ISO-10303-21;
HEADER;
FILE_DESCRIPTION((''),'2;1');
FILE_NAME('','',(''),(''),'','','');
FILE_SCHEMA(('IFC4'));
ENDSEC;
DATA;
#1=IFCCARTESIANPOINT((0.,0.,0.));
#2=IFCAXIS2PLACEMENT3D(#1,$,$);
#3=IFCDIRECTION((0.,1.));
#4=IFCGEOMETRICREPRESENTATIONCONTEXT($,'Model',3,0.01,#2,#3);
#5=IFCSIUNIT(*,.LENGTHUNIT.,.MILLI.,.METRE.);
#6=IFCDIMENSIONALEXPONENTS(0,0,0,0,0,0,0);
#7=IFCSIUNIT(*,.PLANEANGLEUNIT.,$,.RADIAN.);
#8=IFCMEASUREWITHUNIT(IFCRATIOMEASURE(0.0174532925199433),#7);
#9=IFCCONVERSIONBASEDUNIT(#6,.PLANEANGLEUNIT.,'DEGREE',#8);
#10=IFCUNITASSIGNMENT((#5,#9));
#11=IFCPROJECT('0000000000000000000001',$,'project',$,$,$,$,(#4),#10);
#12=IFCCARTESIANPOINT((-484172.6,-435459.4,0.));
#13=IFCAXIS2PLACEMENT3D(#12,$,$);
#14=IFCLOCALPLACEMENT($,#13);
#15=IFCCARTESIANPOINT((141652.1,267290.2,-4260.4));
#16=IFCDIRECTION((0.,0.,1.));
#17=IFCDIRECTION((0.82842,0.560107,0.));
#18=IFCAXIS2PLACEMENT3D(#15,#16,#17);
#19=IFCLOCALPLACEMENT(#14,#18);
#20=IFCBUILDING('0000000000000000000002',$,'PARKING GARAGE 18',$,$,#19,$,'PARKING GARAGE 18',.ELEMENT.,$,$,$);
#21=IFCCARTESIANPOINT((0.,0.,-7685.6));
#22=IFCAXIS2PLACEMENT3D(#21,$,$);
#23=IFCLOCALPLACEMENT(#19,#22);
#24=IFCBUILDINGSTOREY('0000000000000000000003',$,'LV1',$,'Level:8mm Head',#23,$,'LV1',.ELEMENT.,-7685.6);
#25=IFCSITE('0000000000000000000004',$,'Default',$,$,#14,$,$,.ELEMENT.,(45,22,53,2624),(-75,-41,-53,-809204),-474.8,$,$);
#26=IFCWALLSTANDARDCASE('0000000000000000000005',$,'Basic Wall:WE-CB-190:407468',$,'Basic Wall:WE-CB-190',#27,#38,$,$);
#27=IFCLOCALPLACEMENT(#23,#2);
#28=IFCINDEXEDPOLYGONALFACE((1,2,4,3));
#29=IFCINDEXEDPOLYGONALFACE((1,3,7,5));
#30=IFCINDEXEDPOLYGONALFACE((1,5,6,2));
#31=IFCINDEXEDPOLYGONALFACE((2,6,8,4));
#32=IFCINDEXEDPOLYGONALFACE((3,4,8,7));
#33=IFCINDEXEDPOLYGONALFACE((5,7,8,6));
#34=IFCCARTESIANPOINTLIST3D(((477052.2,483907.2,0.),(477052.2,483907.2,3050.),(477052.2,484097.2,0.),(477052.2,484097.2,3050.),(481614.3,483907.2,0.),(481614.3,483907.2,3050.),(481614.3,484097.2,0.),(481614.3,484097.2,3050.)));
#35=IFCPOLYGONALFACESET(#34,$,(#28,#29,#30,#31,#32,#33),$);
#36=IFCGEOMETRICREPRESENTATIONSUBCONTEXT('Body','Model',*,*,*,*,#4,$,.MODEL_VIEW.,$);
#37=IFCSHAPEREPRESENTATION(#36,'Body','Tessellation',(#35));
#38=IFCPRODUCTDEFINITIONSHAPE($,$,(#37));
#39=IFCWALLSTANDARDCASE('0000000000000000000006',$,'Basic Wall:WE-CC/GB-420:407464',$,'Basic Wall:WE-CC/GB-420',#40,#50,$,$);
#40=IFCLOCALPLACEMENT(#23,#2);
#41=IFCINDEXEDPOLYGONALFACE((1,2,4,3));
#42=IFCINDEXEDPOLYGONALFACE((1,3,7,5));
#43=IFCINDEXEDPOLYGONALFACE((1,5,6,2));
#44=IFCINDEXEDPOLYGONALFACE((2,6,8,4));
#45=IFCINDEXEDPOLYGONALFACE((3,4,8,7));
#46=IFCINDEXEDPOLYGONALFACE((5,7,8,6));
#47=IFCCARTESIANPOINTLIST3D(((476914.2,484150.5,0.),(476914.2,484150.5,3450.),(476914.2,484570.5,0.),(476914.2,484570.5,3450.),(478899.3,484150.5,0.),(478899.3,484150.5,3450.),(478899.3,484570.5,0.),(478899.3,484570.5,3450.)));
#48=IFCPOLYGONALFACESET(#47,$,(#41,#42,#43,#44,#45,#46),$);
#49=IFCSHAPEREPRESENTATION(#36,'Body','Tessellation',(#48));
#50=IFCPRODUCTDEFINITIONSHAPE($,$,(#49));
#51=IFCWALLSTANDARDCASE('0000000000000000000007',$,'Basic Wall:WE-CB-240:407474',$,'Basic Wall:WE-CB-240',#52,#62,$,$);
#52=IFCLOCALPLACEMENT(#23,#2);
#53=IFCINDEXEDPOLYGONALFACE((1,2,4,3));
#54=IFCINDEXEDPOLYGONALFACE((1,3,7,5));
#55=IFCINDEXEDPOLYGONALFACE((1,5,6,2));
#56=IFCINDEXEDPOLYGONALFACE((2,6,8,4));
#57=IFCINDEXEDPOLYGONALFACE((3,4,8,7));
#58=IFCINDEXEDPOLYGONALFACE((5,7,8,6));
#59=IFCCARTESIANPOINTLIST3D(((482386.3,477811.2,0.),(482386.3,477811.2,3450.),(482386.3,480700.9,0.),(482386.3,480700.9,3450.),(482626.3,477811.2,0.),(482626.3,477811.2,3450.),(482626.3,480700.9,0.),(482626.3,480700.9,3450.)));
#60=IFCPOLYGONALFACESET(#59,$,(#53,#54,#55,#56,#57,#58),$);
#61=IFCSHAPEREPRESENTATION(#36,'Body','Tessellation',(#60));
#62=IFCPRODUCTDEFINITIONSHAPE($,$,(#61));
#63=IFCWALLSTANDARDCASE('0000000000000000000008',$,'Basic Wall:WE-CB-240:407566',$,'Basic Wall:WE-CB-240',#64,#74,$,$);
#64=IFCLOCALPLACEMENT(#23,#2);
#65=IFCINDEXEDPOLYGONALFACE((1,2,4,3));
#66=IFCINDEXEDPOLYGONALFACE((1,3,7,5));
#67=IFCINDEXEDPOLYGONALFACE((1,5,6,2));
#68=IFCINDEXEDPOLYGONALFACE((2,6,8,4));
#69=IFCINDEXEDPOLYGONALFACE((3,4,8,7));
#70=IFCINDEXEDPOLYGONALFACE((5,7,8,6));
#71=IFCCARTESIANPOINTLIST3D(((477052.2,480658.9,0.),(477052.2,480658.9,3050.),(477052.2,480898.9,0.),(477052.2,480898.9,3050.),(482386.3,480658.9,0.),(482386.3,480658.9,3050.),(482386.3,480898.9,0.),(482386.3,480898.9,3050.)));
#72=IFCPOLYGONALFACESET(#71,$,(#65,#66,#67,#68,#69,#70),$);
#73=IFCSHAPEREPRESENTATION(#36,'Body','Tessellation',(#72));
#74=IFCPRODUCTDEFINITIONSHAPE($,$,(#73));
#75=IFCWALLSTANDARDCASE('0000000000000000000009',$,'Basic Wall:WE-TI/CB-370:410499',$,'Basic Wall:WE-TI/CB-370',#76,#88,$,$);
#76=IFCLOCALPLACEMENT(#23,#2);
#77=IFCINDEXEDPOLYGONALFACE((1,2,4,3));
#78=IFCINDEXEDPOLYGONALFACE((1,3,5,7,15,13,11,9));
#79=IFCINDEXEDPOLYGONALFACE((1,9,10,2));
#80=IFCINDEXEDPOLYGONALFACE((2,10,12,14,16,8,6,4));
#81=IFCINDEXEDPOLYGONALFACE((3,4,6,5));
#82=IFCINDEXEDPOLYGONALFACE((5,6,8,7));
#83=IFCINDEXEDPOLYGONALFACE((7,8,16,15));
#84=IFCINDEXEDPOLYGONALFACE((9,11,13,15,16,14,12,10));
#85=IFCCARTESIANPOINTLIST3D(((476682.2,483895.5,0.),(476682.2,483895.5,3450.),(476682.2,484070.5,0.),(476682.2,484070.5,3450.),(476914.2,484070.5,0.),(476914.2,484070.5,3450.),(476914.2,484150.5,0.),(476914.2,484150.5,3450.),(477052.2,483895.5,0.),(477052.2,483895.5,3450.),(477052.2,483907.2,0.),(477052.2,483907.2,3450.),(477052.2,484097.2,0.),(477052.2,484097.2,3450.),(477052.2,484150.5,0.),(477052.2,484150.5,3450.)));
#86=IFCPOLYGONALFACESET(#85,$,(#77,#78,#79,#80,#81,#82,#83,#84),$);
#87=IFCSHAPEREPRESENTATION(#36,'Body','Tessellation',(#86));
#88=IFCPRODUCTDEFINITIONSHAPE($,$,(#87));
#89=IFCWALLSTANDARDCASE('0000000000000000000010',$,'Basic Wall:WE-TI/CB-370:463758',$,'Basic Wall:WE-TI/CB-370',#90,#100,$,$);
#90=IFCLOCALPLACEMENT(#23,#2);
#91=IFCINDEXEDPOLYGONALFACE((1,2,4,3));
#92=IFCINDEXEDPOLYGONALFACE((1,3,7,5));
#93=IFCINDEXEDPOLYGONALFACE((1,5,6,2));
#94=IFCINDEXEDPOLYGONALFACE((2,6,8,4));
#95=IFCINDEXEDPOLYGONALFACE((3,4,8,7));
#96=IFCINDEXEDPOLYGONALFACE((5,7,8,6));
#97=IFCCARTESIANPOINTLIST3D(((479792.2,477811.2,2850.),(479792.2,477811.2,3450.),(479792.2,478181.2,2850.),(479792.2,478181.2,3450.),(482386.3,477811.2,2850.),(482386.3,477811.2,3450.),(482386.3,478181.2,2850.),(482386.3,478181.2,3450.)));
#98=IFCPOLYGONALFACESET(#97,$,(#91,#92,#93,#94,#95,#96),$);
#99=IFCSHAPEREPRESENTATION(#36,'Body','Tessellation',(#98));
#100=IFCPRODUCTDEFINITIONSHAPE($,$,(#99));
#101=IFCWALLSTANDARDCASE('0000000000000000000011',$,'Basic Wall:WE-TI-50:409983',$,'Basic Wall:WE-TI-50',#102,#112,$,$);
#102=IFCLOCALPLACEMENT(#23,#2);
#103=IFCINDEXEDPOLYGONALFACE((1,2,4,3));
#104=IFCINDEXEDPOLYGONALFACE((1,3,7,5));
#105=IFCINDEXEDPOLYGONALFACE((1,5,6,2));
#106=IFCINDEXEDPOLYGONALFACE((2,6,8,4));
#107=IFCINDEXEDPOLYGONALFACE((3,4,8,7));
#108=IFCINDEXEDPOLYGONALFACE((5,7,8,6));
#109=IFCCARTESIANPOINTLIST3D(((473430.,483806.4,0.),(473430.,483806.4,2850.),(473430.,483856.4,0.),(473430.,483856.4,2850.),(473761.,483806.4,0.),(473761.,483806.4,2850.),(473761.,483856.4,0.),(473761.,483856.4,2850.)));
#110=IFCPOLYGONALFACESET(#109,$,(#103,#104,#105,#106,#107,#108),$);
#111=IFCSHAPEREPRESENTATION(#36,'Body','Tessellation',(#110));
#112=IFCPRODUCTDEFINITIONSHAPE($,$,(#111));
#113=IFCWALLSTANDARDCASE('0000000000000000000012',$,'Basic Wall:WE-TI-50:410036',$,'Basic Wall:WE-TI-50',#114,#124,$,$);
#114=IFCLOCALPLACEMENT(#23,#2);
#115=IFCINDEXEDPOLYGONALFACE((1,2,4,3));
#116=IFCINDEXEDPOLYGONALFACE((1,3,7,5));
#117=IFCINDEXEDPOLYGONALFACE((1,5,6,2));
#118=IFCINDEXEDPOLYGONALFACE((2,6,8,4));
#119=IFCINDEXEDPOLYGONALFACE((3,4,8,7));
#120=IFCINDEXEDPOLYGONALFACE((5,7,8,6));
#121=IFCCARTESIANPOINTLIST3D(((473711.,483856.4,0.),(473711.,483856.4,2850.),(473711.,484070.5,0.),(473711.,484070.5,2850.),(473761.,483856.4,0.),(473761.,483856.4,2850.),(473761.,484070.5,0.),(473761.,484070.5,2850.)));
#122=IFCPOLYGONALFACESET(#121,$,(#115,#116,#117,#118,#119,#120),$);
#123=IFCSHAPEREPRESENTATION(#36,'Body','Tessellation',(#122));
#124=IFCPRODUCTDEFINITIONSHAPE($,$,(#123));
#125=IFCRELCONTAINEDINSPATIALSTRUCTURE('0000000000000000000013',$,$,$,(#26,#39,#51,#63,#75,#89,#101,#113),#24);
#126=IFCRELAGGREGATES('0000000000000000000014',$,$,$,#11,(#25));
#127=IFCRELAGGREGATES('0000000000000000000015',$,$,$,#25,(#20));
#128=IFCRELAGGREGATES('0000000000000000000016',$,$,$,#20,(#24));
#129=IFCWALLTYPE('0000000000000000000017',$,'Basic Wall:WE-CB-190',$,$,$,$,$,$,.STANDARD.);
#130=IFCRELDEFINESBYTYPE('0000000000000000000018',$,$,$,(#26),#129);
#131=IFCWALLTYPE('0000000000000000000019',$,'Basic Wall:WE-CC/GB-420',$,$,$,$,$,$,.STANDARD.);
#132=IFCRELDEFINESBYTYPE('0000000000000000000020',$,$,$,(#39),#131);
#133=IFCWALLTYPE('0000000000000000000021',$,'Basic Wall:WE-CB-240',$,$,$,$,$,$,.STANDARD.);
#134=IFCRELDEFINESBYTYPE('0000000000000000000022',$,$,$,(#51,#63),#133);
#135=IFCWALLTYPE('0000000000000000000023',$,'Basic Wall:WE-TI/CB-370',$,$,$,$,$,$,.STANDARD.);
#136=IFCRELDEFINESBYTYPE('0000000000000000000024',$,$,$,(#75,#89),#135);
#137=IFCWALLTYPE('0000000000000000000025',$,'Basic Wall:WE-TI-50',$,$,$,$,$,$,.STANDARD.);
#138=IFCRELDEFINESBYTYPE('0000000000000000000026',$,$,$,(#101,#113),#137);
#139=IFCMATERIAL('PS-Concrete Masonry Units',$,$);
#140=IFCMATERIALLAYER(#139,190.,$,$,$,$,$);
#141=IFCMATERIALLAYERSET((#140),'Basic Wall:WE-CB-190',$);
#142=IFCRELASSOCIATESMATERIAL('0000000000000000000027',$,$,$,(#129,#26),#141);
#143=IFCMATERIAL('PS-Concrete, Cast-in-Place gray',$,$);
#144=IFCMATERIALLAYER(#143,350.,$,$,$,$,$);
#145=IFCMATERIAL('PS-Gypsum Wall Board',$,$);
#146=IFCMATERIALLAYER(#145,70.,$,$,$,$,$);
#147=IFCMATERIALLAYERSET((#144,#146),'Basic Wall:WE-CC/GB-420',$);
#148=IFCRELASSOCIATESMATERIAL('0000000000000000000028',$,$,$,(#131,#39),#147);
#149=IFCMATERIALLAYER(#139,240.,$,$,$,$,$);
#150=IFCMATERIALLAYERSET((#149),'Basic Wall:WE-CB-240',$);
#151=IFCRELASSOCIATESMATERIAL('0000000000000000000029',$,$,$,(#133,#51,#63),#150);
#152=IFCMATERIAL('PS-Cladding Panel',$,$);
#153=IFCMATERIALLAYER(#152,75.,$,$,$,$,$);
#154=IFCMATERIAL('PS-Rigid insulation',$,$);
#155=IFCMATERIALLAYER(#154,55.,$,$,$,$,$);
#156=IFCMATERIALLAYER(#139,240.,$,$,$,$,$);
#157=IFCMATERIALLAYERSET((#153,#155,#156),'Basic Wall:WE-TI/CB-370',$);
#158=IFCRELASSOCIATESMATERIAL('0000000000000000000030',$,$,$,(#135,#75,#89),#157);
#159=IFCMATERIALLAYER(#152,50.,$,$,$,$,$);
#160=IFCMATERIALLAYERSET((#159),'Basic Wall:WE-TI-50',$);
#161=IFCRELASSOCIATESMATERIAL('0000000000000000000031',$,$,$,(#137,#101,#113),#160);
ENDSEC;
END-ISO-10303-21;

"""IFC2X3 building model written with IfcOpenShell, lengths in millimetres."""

from ifc_helpers import new_model, entity, si_unit, converted_unit, direction, frame, frame_2d, origin, place, context, subcontext, project, spatial, polyline, rectangle, outline, extrude, clip, bounded_halfspace, material, layer, layer_set, layer_usage, type_object, element, save


model = new_model("IFC2X3")

# Units and contexts
model_context = context("Model", 3, precision=0.01, world=origin(), true_north=direction((0.0, 1.0)))
body_context = subcontext(model_context, "Body", "Model", "MODEL_VIEW")
ifc_project = project(units=[si_unit("LENGTHUNIT", "METRE", prefix="MILLI"), converted_unit("PLANEANGLEUNIT", "DEGREE", entity("IfcRatioMeasure", 0.0174532925199433), si_unit("PLANEANGLEUNIT", "RADIAN"), dimensions=[0, 0, 0, 0, 0, 0, 0])], contexts=[model_context])

# Site, building, storey
site_placement = place(None, frame((-484172.6, -435459.4, 0.0)))
site = spatial("IfcSite", under=ifc_project, at=site_placement, Name="Default", CompositionType="ELEMENT", RefLatitude=(45, 22, 53, 2624), RefLongitude=(-75, -41, -53, -809204), RefElevation=-474.8)
building_placement = place(site_placement, frame((141652.1, 267290.2, -4260.4), z_axis=(0.0, 0.0, 1.0), x_axis=(0.82842, 0.560107, 0.0)))
building = spatial("IfcBuilding", under=site, at=building_placement, Name="PARKING GARAGE 18", LongName="PARKING GARAGE 18", CompositionType="ELEMENT")
storey_placement = place(building_placement, frame((0.0, 0.0, -7685.6)))
storey = spatial("IfcBuildingStorey", under=building, at=storey_placement, Name="LV1", ObjectType="Level:8mm Head", LongName="LV1", CompositionType="ELEMENT", Elevation=-7685.6)

# Walls
ifc_material_1 = material(Name="PS-Concrete Masonry Units")
ifc_layer_1 = layer(ifc_material_1, 190.0)
ifc_layer_set_1 = layer_set([ifc_layer_1], Name="Basic Wall:WE-CB-190")
ifc_layer_usage_1 = layer_usage(ifc_layer_set_1, "AXIS2", "NEGATIVE", 95.0)
wall_type_1 = type_object("IfcWallType", Name="Basic Wall:WE-CB-190", PredefinedType="STANDARD", material=ifc_layer_set_1)
wall_1_placement = place(storey_placement, frame((477052.2, 484002.2, 0.0)))
element("IfcWallStandardCase", 1, at=wall_1_placement, inside=storey, type_object=wall_type_1, material=ifc_layer_usage_1, Name="Basic Wall:WE-CB-190:407468", ObjectType="Basic Wall:WE-CB-190", context=body_context, shape_type="SweptSolid", body=[
    extrude(rectangle(XDim=4562.1, YDim=190.0, at=frame_2d((2281.0, 0.0), x_axis=(-1.0, 0.0))), origin(), (0.0, 0.0, 1.0), 3050.0),
])
ifc_material_2 = material(Name="PS-Cladding Panel")
ifc_material_3 = material(Name="PS-Concrete, Cast-in-Place gray")
ifc_material_4 = material(Name="PS-Gypsum Wall Board")
ifc_layer_2 = layer(ifc_material_3, 350.0)
ifc_layer_3 = layer(ifc_material_4, 70.0)
ifc_layer_set_2 = layer_set([ifc_layer_2, ifc_layer_3], Name="Basic Wall:WE-CC/GB-420")
ifc_layer_usage_2 = layer_usage(ifc_layer_set_2, "AXIS2", "POSITIVE", -210.0)
wall_type_2 = type_object("IfcWallType", Name="Basic Wall:WE-CC/GB-420", PredefinedType="STANDARD", material=ifc_layer_set_2)
wall_2_placement = place(storey_placement, frame((476914.2, 484360.5, 0.0)))
element("IfcWallStandardCase", 2, at=wall_2_placement, inside=storey, type_object=wall_type_2, material=ifc_layer_usage_2, Name="Basic Wall:WE-CC/GB-420:407464", ObjectType="Basic Wall:WE-CC/GB-420", context=body_context, shape_type="SweptSolid", body=[
    extrude(rectangle(XDim=1985.1, YDim=420.0, at=frame_2d((992.5, 0.0), x_axis=(-1.0, 0.0))), origin(), (0.0, 0.0, 1.0), 3450.0),
])
ifc_layer_4 = layer(ifc_material_1, 240.0)
ifc_layer_set_3 = layer_set([ifc_layer_4], Name="Basic Wall:WE-CB-240")
ifc_layer_usage_3 = layer_usage(ifc_layer_set_3, "AXIS2", "NEGATIVE", 120.0)
wall_type_3 = type_object("IfcWallType", Name="Basic Wall:WE-CB-240", PredefinedType="STANDARD", material=ifc_layer_set_3)
wall_3_placement = place(storey_placement, frame((482506.3, 480700.9, 0.0), z_axis=(0.0, 0.0, 1.0), x_axis=(0.0, -1.0, 0.0)))
element("IfcWallStandardCase", 3, at=wall_3_placement, inside=storey, type_object=wall_type_3, material=ifc_layer_usage_3, Name="Basic Wall:WE-CB-240:407474", ObjectType="Basic Wall:WE-CB-240", context=body_context, shape_type="SweptSolid", body=[
    extrude(rectangle(XDim=2889.7, YDim=240.0, at=frame_2d((1444.8, 0.0), x_axis=(-1.0, 0.0))), origin(), (0.0, 0.0, 1.0), 3450.0),
])
ifc_layer_usage_4 = layer_usage(ifc_layer_set_3, "AXIS2", "NEGATIVE", 120.0)
wall_4_placement = place(storey_placement, frame((477052.2, 480778.9, 0.0)))
element("IfcWallStandardCase", 4, at=wall_4_placement, inside=storey, type_object=wall_type_3, material=ifc_layer_usage_4, Name="Basic Wall:WE-CB-240:407566", ObjectType="Basic Wall:WE-CB-240", context=body_context, shape_type="SweptSolid", body=[
    extrude(rectangle(XDim=5334.1, YDim=240.0, at=frame_2d((2667.0, 0.0), x_axis=(-1.0, 0.0))), origin(), (0.0, 0.0, 1.0), 3050.0),
])
ifc_layer_5 = layer(ifc_material_2, 75.0)
ifc_material_5 = material(Name="PS-Rigid insulation")
ifc_layer_6 = layer(ifc_material_5, 55.0)
ifc_layer_7 = layer(ifc_material_1, 240.0)
ifc_layer_set_4 = layer_set([ifc_layer_5, ifc_layer_6, ifc_layer_7], Name="Basic Wall:WE-TI/CB-370")
ifc_layer_usage_5 = layer_usage(ifc_layer_set_4, "AXIS2", "NEGATIVE", 185.0)
wall_type_4 = type_object("IfcWallType", Name="Basic Wall:WE-TI/CB-370", PredefinedType="STANDARD", material=ifc_layer_set_4)
wall_5_placement = place(storey_placement, frame((476867.2, 483895.5, 0.0), z_axis=(0.0, 0.0, 1.0), x_axis=(0.0, 1.0, 0.0)))
element("IfcWallStandardCase", 5, at=wall_5_placement, inside=storey, type_object=wall_type_4, material=ifc_layer_usage_5, Name="Basic Wall:WE-TI/CB-370:410499", ObjectType="Basic Wall:WE-TI/CB-370", context=body_context, shape_type="SweptSolid", body=[
    extrude(outline(polyline([(255.0, -185.0), (255.0, -47.0), (175.0, -47.0), (175.0, 185.0), (0.0, 185.0), (0.0, -185.0), (11.7, -185.0), (201.7, -185.0), (255.0, -185.0)])), origin(), (0.0, 0.0, 1.0), 3450.0),
])
ifc_layer_usage_6 = layer_usage(ifc_layer_set_4, "AXIS2", "NEGATIVE", 185.0)
wall_6_placement = place(storey_placement, frame((482386.3, 477996.2, 2850.0), z_axis=(0.0, 0.0, 1.0), x_axis=(-1.0, 0.0, 0.0)))
element("IfcWallStandardCase", 6, at=wall_6_placement, inside=storey, type_object=wall_type_4, material=ifc_layer_usage_6, Name="Basic Wall:WE-TI/CB-370:463758", ObjectType="Basic Wall:WE-TI/CB-370", context=body_context, shape_type="SweptSolid", body=[
    extrude(rectangle(XDim=2594.1, YDim=370.0, at=frame_2d((1297.0, 0.0), x_axis=(-1.0, 0.0))), origin(), (0.0, 0.0, 1.0), 600.0),
])
ifc_layer_8 = layer(ifc_material_2, 50.0)
ifc_layer_set_5 = layer_set([ifc_layer_8], Name="Basic Wall:WE-TI-50")
ifc_layer_usage_7 = layer_usage(ifc_layer_set_5, "AXIS2", "POSITIVE", -25.0)
wall_type_5 = type_object("IfcWallType", Name="Basic Wall:WE-TI-50", PredefinedType="STANDARD", material=ifc_layer_set_5)
wall_7_placement = place(storey_placement, frame((473430.0, 483831.4, 0.0)))
element("IfcWallStandardCase", 7, at=wall_7_placement, inside=storey, type_object=wall_type_5, material=ifc_layer_usage_7, Name="Basic Wall:WE-TI-50:409983", ObjectType="Basic Wall:WE-TI-50", context=body_context, shape_type="Clipping", body=[
    clip(extrude(rectangle(XDim=331.0, YDim=50.0, at=frame_2d((165.5, 0.0), x_axis=(-1.0, 0.0))), origin(), (0.0, 0.0, 1.0), 2850.0), bounded_halfspace(frame((0.0, -25.0, 2850.0), z_axis=(0.0, 0.0, -1.0), x_axis=(1.0, 0.0, 0.0)), True, frame((0.0, -25.0, 2850.0), z_axis=(0.0, 0.0, -1.0), x_axis=(1.0, 0.0, 0.0)), polyline([(0.0, 0.0), (0.0, -50.0), (281.0, -50.0), (331.0, -50.0), (331.0, 0.0), (0.0, 0.0)]))),
])
ifc_layer_usage_8 = layer_usage(ifc_layer_set_5, "AXIS2", "POSITIVE", -25.0)
wall_8_placement = place(storey_placement, frame((473736.0, 483856.4, 0.0), z_axis=(0.0, 0.0, 1.0), x_axis=(0.0, 1.0, 0.0)))
element("IfcWallStandardCase", 8, at=wall_8_placement, inside=storey, type_object=wall_type_5, material=ifc_layer_usage_8, Name="Basic Wall:WE-TI-50:410036", ObjectType="Basic Wall:WE-TI-50", context=body_context, shape_type="Clipping", body=[
    clip(extrude(rectangle(XDim=214.1, YDim=50.0, at=frame_2d((107.0, 0.0), x_axis=(-1.0, 0.0))), origin(), (0.0, 0.0, 1.0), 2850.0), bounded_halfspace(frame((0.0, -25.0, 2850.0), z_axis=(0.0, 0.0, -1.0), x_axis=(0.0, -1.0, 0.0)), True, frame((0.0, -25.0, 2850.0), z_axis=(0.0, 0.0, -1.0), x_axis=(0.0, -1.0, 0.0)), polyline([(0.0, 0.0), (-50.0, 0.0), (-50.0, -214.1), (0.0, -214.1), (0.0, 0.0)]))),
])

save(model, "model.ifc")
